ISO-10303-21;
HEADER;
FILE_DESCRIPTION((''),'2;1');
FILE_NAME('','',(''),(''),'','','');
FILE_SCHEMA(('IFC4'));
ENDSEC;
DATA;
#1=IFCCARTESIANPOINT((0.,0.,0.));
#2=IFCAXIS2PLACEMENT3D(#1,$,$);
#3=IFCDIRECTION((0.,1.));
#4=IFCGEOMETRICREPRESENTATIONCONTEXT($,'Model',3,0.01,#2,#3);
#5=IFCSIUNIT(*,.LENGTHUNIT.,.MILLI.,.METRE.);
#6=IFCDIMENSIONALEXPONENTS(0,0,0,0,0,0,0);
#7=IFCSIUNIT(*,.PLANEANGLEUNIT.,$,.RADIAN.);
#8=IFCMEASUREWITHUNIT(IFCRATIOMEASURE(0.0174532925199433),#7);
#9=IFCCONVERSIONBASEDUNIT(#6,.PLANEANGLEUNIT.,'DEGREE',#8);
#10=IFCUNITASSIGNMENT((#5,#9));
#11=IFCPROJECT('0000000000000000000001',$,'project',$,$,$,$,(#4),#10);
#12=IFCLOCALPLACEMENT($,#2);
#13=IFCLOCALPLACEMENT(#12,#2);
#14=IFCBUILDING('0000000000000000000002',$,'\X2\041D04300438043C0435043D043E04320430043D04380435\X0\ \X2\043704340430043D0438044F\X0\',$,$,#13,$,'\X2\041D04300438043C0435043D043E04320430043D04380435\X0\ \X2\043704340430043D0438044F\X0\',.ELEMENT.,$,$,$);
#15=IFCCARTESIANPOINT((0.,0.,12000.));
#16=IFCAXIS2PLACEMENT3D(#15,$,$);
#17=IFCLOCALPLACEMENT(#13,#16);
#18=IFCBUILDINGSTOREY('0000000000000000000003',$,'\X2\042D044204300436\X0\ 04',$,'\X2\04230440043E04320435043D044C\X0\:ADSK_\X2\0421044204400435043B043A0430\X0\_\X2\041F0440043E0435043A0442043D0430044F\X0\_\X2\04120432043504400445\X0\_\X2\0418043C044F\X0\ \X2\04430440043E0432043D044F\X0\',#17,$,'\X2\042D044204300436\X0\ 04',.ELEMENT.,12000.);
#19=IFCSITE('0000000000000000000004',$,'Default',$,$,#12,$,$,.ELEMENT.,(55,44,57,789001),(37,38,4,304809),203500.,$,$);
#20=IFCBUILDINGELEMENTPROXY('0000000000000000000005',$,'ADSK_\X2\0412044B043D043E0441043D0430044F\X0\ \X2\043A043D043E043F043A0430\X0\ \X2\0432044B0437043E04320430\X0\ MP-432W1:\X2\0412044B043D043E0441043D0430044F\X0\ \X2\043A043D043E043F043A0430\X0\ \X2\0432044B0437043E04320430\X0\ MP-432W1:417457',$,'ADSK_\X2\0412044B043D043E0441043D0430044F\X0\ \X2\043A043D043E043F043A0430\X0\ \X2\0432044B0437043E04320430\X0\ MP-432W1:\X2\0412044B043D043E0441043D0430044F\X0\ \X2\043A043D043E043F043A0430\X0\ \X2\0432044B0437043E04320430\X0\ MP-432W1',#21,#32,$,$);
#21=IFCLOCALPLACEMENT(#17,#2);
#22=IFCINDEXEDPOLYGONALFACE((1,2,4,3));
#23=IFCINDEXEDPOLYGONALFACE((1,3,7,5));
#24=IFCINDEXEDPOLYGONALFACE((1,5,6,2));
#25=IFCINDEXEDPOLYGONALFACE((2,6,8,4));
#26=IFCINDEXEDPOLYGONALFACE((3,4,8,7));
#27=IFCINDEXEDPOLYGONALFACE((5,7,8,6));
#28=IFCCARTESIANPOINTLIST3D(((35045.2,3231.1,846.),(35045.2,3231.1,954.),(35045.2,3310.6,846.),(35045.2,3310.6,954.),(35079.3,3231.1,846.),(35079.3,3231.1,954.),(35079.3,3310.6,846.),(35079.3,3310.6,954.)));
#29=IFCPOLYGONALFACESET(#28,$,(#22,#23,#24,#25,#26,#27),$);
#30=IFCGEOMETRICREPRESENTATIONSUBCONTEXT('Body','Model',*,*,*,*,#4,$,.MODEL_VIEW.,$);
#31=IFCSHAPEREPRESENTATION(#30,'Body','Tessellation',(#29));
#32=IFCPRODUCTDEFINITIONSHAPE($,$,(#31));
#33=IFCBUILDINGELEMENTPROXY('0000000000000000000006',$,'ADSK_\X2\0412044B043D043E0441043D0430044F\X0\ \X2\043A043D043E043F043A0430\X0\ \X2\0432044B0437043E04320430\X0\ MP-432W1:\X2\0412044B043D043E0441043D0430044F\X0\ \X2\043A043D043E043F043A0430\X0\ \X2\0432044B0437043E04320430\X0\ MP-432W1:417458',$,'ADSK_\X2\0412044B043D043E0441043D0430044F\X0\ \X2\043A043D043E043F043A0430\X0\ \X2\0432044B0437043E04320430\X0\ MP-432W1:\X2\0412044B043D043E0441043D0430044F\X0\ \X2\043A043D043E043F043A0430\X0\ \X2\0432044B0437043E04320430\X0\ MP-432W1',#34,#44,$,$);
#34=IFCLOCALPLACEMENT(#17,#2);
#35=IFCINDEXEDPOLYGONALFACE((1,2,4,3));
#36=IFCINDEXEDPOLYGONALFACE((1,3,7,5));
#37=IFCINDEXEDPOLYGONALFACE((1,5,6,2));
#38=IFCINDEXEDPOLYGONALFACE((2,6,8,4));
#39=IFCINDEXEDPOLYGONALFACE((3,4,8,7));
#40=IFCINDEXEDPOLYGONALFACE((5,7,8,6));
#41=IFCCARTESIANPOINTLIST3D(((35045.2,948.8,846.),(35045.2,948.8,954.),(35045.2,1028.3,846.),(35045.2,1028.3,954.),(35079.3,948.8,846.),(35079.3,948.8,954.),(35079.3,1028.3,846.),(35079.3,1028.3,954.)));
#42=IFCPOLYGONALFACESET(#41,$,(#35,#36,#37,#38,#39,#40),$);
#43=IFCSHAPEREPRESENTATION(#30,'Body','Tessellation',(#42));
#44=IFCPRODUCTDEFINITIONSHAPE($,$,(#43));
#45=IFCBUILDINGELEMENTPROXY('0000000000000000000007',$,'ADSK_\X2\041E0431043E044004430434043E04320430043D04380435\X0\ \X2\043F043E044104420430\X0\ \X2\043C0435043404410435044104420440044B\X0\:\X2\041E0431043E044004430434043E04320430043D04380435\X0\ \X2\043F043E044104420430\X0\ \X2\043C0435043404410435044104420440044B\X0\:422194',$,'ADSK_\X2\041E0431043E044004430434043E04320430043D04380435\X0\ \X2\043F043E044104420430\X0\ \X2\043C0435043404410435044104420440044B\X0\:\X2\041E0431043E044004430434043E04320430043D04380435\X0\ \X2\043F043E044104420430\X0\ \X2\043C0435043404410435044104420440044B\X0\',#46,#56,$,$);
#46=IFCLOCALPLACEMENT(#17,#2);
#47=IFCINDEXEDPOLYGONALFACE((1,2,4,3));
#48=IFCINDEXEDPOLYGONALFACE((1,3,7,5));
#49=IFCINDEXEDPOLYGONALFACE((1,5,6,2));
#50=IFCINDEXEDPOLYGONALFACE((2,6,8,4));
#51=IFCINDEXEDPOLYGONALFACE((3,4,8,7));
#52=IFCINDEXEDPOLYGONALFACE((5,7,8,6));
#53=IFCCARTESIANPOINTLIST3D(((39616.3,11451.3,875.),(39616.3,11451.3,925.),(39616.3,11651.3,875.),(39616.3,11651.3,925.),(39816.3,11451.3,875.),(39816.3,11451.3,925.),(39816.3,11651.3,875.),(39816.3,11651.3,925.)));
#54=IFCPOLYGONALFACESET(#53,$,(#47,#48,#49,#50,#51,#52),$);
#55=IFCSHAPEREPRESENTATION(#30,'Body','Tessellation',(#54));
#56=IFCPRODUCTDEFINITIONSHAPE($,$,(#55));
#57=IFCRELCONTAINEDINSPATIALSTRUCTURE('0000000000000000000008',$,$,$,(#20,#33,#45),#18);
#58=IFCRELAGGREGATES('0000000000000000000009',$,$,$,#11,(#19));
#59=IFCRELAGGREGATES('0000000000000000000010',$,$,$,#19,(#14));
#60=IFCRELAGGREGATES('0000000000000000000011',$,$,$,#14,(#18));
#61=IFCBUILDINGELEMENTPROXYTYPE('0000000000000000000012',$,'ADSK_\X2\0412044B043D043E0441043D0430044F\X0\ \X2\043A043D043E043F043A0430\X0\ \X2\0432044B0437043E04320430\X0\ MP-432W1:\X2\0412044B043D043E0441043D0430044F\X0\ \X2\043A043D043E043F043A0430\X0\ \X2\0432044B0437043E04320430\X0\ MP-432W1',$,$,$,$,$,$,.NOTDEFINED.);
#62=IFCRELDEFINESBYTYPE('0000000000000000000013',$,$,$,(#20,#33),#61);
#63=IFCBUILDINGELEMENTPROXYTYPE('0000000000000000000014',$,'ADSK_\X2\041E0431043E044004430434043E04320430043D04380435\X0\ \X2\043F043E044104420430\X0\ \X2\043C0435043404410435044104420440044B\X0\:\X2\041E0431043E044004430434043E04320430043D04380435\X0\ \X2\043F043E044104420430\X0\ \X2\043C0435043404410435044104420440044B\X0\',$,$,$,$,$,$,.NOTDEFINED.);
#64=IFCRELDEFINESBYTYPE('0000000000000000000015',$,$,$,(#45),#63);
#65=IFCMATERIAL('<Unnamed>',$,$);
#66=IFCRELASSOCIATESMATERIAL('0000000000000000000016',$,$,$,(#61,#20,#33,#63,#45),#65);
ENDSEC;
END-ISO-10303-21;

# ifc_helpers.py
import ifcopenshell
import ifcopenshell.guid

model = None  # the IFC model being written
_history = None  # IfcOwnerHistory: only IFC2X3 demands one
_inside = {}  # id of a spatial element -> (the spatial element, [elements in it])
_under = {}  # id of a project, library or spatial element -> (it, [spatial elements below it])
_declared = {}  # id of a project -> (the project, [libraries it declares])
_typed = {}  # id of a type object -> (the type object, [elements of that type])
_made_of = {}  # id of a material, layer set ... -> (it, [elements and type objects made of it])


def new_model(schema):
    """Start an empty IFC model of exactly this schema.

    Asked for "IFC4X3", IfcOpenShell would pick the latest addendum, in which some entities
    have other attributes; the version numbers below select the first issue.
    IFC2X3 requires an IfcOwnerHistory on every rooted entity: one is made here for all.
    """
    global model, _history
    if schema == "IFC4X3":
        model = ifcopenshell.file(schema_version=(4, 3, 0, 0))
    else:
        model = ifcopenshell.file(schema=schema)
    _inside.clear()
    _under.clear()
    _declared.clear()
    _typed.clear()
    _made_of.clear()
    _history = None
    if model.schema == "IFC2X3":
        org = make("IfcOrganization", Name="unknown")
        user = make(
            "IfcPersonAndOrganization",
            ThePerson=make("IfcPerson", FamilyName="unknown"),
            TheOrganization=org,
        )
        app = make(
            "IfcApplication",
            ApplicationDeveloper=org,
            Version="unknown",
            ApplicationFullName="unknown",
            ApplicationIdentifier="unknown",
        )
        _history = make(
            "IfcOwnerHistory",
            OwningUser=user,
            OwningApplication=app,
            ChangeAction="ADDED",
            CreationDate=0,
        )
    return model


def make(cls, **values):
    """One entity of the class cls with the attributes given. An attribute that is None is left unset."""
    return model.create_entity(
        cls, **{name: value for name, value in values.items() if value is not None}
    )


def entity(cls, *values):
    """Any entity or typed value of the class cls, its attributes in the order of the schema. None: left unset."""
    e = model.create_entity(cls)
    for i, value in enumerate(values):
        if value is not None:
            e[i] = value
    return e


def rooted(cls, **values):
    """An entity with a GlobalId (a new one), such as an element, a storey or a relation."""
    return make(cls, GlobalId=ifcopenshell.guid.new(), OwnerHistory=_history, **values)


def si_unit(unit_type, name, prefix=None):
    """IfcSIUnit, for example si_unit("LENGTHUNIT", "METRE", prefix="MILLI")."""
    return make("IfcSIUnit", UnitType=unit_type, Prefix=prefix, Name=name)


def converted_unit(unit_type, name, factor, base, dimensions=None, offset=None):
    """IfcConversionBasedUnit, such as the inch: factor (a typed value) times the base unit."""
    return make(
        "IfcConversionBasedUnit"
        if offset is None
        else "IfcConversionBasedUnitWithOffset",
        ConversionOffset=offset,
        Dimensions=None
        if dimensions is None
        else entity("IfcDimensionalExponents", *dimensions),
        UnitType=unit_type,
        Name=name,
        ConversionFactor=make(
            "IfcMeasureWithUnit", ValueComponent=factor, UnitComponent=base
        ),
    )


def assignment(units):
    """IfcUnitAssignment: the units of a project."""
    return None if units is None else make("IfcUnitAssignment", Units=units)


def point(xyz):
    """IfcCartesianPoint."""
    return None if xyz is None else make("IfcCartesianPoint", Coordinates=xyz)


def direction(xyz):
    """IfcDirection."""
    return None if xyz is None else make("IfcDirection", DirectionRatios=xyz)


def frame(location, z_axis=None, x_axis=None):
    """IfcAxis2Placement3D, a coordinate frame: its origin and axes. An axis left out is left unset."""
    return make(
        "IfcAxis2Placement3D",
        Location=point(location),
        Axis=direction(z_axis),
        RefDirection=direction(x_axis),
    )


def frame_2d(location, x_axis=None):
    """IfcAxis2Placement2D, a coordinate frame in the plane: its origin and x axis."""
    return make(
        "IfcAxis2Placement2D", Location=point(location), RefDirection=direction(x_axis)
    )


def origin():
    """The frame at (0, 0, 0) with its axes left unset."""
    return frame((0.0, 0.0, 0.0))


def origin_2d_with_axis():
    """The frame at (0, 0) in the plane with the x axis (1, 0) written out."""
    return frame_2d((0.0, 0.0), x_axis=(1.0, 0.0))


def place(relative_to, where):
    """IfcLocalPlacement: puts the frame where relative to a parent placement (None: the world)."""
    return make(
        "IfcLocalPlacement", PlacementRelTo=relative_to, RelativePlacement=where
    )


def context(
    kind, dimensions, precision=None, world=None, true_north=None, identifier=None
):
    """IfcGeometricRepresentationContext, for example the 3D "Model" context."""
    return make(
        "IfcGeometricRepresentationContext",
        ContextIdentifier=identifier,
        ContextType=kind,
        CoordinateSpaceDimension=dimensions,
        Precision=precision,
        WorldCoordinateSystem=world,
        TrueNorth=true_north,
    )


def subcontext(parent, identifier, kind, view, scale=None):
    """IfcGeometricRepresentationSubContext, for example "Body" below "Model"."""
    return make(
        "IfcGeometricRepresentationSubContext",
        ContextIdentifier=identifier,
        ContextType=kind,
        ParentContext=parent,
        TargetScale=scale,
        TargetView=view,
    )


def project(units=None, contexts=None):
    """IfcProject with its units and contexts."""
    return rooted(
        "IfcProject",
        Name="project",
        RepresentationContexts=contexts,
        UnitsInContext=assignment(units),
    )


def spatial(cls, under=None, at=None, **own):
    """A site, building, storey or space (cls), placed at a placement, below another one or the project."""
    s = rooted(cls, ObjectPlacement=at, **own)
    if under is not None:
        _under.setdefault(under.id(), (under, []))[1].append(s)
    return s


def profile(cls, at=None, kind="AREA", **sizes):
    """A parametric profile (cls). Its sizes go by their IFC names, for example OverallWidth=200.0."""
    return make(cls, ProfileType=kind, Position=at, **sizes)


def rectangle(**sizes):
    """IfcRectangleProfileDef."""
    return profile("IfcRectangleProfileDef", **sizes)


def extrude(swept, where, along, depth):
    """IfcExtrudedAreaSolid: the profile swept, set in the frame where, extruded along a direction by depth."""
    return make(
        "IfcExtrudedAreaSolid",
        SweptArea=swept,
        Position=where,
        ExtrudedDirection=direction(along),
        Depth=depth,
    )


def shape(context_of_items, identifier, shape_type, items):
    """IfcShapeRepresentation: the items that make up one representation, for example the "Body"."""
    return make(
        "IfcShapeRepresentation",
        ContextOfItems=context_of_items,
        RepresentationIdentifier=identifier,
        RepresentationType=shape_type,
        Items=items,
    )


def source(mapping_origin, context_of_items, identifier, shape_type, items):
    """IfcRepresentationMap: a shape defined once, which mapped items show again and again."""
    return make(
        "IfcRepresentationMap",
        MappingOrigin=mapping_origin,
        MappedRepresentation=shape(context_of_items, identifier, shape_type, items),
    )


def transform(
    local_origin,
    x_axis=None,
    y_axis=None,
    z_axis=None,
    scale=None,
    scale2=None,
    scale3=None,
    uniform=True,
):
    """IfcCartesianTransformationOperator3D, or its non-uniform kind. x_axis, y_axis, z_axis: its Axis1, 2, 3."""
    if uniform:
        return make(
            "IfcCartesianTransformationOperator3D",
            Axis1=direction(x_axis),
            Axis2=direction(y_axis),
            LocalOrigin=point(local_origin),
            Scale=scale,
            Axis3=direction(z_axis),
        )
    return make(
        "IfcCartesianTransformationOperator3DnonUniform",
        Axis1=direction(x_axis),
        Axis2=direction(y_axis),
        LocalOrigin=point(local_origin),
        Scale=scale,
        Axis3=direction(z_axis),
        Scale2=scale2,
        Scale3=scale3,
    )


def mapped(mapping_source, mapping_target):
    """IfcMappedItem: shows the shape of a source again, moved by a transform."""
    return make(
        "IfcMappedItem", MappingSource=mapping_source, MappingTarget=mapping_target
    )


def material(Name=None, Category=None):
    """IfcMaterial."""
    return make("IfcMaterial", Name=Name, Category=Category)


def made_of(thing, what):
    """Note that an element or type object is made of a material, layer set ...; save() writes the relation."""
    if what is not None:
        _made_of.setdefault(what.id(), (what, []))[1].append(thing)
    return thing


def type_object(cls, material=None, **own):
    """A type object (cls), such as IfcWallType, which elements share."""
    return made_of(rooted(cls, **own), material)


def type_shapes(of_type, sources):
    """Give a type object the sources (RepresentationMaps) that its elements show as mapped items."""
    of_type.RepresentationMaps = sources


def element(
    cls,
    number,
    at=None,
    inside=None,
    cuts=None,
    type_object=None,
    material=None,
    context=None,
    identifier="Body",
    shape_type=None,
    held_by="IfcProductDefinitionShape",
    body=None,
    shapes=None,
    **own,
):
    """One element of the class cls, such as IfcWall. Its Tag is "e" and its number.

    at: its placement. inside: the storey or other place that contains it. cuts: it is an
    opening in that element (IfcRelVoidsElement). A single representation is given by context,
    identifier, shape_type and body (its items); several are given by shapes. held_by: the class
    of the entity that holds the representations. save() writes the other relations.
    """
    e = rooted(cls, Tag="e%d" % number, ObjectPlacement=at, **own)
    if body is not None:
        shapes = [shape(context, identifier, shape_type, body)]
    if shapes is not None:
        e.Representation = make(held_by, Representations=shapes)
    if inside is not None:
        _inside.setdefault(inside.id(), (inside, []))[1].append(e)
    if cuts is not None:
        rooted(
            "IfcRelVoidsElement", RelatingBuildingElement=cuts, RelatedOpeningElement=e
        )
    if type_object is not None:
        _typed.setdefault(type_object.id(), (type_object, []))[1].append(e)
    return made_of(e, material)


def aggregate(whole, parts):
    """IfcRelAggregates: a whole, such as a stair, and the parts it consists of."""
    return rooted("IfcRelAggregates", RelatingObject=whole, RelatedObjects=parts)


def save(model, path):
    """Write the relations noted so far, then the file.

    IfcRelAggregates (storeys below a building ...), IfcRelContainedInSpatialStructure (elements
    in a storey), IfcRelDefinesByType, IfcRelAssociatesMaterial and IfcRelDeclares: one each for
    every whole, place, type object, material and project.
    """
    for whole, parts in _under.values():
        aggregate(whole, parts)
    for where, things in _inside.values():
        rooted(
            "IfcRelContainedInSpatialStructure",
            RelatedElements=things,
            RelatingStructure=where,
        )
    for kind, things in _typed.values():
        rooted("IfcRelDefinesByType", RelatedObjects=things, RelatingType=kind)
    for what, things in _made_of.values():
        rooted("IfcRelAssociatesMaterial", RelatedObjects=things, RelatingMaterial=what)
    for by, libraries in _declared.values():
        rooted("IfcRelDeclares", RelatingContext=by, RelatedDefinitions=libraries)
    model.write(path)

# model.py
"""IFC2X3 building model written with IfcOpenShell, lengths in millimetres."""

from ifc_helpers import new_model, entity, si_unit, converted_unit, direction, frame, origin, origin_2d_with_axis, place, context, subcontext, project, spatial, rectangle, extrude, source, transform, mapped, material, type_object, type_shapes, element, save


model = new_model("IFC2X3")

# Units and contexts
model_context = context("Model", 3, precision=0.01, world=origin(), true_north=direction((0.0, 1.0)))
body_context = subcontext(model_context, "Body", "Model", "MODEL_VIEW")
ifc_project = project(units=[si_unit("LENGTHUNIT", "METRE", prefix="MILLI"), converted_unit("PLANEANGLEUNIT", "DEGREE", entity("IfcRatioMeasure", 0.0174532925199433), si_unit("PLANEANGLEUNIT", "RADIAN"), dimensions=[0, 0, 0, 0, 0, 0, 0])], contexts=[model_context])

# Site, building, storey
site_placement = place(None, origin())
site = spatial("IfcSite", under=ifc_project, at=site_placement, Name="Default", CompositionType="ELEMENT", RefLatitude=(55, 44, 57, 789001), RefLongitude=(37, 38, 4, 304809), RefElevation=203500.0)
building_placement = place(site_placement, origin())
building = spatial("IfcBuilding", under=site, at=building_placement, Name="Наименование здания", LongName="Наименование здания", CompositionType="ELEMENT")
storey_placement = place(building_placement, frame((0.0, 0.0, 12000.0)))
storey = spatial("IfcBuildingStorey", under=building, at=storey_placement, Name="Этаж 04", ObjectType="Уровень:ADSK_Стрелка_Проектная_Вверх_Имя уровня", LongName="Этаж 04", CompositionType="ELEMENT", Elevation=12000.0)

# Building element proxies
ifc_material = material(Name="<Unnamed>")
building_element_proxy_type_1 = type_object("IfcBuildingElementProxyType", Name="ADSK_Выносная кнопка вызова MP-432W1:Выносная кнопка вызова MP-432W1", PredefinedType="NOTDEFINED", material=ifc_material)
shared_shape_1 = source(origin(), body_context, "Body", "SweptSolid", [
    extrude(rectangle(XDim=79.5, YDim=34.1, at=origin_2d_with_axis()), frame((0.0, 15.0, -54.0), z_axis=(0.0, 0.0, 1.0), x_axis=(-1.0, 0.0, 0.0)), (0.0, 0.0, 1.0), 108.0),
])
type_shapes(building_element_proxy_type_1, [shared_shape_1])
for number, where, z_axis, x_axis, name in (
    (1, (35077.2, 3270.8, 900.0), (0.0, 0.0, 1.0), (0.0, 1.0, 0.0), "ADSK_Выносная кнопка вызова MP-432W1:Выносная кнопка вызова MP-432W1:417457"),
    (2, (35077.2, 988.6, 900.0), (0.0, 0.0, 1.0), (0.0, 1.0, 0.0), "ADSK_Выносная кнопка вызова MP-432W1:Выносная кнопка вызова MP-432W1:417458"),
):
    element("IfcBuildingElementProxy", number, at=place(storey_placement, frame(where, z_axis=z_axis, x_axis=x_axis)), inside=storey, type_object=building_element_proxy_type_1, material=ifc_material, Name=name, ObjectType="ADSK_Выносная кнопка вызова MP-432W1:Выносная кнопка вызова MP-432W1", context=body_context, shape_type="MappedRepresentation", body=[
        mapped(shared_shape_1, transform((0.0, 0.0, 0.0), scale=1.0)),
    ])
building_element_proxy_type_2 = type_object("IfcBuildingElementProxyType", Name="ADSK_Оборудование поста медсестры:Оборудование поста медсестры", PredefinedType="NOTDEFINED", material=ifc_material)
shared_shape_2 = source(origin(), body_context, "Body", "SweptSolid", [
    extrude(rectangle(XDim=200.0, YDim=200.0, at=origin_2d_with_axis()), frame((0.0, -68.0, -25.0), z_axis=(0.0, 0.0, 1.0), x_axis=(-1.0, 0.0, 0.0)), (0.0, 0.0, 1.0), 50.0),
])
type_shapes(building_element_proxy_type_2, [shared_shape_2])
proxy_1_placement = place(storey_placement, frame((39716.3, 11619.3, 900.0)))
element("IfcBuildingElementProxy", 3, at=proxy_1_placement, inside=storey, type_object=building_element_proxy_type_2, material=ifc_material, Name="ADSK_Оборудование поста медсестры:Оборудование поста медсестры:422194", ObjectType="ADSK_Оборудование поста медсестры:Оборудование поста медсестры", context=body_context, shape_type="MappedRepresentation", body=[
    mapped(shared_shape_2, transform((0.0, 0.0, 0.0), scale=1.0)),
])

save(model, "model.ifc")
